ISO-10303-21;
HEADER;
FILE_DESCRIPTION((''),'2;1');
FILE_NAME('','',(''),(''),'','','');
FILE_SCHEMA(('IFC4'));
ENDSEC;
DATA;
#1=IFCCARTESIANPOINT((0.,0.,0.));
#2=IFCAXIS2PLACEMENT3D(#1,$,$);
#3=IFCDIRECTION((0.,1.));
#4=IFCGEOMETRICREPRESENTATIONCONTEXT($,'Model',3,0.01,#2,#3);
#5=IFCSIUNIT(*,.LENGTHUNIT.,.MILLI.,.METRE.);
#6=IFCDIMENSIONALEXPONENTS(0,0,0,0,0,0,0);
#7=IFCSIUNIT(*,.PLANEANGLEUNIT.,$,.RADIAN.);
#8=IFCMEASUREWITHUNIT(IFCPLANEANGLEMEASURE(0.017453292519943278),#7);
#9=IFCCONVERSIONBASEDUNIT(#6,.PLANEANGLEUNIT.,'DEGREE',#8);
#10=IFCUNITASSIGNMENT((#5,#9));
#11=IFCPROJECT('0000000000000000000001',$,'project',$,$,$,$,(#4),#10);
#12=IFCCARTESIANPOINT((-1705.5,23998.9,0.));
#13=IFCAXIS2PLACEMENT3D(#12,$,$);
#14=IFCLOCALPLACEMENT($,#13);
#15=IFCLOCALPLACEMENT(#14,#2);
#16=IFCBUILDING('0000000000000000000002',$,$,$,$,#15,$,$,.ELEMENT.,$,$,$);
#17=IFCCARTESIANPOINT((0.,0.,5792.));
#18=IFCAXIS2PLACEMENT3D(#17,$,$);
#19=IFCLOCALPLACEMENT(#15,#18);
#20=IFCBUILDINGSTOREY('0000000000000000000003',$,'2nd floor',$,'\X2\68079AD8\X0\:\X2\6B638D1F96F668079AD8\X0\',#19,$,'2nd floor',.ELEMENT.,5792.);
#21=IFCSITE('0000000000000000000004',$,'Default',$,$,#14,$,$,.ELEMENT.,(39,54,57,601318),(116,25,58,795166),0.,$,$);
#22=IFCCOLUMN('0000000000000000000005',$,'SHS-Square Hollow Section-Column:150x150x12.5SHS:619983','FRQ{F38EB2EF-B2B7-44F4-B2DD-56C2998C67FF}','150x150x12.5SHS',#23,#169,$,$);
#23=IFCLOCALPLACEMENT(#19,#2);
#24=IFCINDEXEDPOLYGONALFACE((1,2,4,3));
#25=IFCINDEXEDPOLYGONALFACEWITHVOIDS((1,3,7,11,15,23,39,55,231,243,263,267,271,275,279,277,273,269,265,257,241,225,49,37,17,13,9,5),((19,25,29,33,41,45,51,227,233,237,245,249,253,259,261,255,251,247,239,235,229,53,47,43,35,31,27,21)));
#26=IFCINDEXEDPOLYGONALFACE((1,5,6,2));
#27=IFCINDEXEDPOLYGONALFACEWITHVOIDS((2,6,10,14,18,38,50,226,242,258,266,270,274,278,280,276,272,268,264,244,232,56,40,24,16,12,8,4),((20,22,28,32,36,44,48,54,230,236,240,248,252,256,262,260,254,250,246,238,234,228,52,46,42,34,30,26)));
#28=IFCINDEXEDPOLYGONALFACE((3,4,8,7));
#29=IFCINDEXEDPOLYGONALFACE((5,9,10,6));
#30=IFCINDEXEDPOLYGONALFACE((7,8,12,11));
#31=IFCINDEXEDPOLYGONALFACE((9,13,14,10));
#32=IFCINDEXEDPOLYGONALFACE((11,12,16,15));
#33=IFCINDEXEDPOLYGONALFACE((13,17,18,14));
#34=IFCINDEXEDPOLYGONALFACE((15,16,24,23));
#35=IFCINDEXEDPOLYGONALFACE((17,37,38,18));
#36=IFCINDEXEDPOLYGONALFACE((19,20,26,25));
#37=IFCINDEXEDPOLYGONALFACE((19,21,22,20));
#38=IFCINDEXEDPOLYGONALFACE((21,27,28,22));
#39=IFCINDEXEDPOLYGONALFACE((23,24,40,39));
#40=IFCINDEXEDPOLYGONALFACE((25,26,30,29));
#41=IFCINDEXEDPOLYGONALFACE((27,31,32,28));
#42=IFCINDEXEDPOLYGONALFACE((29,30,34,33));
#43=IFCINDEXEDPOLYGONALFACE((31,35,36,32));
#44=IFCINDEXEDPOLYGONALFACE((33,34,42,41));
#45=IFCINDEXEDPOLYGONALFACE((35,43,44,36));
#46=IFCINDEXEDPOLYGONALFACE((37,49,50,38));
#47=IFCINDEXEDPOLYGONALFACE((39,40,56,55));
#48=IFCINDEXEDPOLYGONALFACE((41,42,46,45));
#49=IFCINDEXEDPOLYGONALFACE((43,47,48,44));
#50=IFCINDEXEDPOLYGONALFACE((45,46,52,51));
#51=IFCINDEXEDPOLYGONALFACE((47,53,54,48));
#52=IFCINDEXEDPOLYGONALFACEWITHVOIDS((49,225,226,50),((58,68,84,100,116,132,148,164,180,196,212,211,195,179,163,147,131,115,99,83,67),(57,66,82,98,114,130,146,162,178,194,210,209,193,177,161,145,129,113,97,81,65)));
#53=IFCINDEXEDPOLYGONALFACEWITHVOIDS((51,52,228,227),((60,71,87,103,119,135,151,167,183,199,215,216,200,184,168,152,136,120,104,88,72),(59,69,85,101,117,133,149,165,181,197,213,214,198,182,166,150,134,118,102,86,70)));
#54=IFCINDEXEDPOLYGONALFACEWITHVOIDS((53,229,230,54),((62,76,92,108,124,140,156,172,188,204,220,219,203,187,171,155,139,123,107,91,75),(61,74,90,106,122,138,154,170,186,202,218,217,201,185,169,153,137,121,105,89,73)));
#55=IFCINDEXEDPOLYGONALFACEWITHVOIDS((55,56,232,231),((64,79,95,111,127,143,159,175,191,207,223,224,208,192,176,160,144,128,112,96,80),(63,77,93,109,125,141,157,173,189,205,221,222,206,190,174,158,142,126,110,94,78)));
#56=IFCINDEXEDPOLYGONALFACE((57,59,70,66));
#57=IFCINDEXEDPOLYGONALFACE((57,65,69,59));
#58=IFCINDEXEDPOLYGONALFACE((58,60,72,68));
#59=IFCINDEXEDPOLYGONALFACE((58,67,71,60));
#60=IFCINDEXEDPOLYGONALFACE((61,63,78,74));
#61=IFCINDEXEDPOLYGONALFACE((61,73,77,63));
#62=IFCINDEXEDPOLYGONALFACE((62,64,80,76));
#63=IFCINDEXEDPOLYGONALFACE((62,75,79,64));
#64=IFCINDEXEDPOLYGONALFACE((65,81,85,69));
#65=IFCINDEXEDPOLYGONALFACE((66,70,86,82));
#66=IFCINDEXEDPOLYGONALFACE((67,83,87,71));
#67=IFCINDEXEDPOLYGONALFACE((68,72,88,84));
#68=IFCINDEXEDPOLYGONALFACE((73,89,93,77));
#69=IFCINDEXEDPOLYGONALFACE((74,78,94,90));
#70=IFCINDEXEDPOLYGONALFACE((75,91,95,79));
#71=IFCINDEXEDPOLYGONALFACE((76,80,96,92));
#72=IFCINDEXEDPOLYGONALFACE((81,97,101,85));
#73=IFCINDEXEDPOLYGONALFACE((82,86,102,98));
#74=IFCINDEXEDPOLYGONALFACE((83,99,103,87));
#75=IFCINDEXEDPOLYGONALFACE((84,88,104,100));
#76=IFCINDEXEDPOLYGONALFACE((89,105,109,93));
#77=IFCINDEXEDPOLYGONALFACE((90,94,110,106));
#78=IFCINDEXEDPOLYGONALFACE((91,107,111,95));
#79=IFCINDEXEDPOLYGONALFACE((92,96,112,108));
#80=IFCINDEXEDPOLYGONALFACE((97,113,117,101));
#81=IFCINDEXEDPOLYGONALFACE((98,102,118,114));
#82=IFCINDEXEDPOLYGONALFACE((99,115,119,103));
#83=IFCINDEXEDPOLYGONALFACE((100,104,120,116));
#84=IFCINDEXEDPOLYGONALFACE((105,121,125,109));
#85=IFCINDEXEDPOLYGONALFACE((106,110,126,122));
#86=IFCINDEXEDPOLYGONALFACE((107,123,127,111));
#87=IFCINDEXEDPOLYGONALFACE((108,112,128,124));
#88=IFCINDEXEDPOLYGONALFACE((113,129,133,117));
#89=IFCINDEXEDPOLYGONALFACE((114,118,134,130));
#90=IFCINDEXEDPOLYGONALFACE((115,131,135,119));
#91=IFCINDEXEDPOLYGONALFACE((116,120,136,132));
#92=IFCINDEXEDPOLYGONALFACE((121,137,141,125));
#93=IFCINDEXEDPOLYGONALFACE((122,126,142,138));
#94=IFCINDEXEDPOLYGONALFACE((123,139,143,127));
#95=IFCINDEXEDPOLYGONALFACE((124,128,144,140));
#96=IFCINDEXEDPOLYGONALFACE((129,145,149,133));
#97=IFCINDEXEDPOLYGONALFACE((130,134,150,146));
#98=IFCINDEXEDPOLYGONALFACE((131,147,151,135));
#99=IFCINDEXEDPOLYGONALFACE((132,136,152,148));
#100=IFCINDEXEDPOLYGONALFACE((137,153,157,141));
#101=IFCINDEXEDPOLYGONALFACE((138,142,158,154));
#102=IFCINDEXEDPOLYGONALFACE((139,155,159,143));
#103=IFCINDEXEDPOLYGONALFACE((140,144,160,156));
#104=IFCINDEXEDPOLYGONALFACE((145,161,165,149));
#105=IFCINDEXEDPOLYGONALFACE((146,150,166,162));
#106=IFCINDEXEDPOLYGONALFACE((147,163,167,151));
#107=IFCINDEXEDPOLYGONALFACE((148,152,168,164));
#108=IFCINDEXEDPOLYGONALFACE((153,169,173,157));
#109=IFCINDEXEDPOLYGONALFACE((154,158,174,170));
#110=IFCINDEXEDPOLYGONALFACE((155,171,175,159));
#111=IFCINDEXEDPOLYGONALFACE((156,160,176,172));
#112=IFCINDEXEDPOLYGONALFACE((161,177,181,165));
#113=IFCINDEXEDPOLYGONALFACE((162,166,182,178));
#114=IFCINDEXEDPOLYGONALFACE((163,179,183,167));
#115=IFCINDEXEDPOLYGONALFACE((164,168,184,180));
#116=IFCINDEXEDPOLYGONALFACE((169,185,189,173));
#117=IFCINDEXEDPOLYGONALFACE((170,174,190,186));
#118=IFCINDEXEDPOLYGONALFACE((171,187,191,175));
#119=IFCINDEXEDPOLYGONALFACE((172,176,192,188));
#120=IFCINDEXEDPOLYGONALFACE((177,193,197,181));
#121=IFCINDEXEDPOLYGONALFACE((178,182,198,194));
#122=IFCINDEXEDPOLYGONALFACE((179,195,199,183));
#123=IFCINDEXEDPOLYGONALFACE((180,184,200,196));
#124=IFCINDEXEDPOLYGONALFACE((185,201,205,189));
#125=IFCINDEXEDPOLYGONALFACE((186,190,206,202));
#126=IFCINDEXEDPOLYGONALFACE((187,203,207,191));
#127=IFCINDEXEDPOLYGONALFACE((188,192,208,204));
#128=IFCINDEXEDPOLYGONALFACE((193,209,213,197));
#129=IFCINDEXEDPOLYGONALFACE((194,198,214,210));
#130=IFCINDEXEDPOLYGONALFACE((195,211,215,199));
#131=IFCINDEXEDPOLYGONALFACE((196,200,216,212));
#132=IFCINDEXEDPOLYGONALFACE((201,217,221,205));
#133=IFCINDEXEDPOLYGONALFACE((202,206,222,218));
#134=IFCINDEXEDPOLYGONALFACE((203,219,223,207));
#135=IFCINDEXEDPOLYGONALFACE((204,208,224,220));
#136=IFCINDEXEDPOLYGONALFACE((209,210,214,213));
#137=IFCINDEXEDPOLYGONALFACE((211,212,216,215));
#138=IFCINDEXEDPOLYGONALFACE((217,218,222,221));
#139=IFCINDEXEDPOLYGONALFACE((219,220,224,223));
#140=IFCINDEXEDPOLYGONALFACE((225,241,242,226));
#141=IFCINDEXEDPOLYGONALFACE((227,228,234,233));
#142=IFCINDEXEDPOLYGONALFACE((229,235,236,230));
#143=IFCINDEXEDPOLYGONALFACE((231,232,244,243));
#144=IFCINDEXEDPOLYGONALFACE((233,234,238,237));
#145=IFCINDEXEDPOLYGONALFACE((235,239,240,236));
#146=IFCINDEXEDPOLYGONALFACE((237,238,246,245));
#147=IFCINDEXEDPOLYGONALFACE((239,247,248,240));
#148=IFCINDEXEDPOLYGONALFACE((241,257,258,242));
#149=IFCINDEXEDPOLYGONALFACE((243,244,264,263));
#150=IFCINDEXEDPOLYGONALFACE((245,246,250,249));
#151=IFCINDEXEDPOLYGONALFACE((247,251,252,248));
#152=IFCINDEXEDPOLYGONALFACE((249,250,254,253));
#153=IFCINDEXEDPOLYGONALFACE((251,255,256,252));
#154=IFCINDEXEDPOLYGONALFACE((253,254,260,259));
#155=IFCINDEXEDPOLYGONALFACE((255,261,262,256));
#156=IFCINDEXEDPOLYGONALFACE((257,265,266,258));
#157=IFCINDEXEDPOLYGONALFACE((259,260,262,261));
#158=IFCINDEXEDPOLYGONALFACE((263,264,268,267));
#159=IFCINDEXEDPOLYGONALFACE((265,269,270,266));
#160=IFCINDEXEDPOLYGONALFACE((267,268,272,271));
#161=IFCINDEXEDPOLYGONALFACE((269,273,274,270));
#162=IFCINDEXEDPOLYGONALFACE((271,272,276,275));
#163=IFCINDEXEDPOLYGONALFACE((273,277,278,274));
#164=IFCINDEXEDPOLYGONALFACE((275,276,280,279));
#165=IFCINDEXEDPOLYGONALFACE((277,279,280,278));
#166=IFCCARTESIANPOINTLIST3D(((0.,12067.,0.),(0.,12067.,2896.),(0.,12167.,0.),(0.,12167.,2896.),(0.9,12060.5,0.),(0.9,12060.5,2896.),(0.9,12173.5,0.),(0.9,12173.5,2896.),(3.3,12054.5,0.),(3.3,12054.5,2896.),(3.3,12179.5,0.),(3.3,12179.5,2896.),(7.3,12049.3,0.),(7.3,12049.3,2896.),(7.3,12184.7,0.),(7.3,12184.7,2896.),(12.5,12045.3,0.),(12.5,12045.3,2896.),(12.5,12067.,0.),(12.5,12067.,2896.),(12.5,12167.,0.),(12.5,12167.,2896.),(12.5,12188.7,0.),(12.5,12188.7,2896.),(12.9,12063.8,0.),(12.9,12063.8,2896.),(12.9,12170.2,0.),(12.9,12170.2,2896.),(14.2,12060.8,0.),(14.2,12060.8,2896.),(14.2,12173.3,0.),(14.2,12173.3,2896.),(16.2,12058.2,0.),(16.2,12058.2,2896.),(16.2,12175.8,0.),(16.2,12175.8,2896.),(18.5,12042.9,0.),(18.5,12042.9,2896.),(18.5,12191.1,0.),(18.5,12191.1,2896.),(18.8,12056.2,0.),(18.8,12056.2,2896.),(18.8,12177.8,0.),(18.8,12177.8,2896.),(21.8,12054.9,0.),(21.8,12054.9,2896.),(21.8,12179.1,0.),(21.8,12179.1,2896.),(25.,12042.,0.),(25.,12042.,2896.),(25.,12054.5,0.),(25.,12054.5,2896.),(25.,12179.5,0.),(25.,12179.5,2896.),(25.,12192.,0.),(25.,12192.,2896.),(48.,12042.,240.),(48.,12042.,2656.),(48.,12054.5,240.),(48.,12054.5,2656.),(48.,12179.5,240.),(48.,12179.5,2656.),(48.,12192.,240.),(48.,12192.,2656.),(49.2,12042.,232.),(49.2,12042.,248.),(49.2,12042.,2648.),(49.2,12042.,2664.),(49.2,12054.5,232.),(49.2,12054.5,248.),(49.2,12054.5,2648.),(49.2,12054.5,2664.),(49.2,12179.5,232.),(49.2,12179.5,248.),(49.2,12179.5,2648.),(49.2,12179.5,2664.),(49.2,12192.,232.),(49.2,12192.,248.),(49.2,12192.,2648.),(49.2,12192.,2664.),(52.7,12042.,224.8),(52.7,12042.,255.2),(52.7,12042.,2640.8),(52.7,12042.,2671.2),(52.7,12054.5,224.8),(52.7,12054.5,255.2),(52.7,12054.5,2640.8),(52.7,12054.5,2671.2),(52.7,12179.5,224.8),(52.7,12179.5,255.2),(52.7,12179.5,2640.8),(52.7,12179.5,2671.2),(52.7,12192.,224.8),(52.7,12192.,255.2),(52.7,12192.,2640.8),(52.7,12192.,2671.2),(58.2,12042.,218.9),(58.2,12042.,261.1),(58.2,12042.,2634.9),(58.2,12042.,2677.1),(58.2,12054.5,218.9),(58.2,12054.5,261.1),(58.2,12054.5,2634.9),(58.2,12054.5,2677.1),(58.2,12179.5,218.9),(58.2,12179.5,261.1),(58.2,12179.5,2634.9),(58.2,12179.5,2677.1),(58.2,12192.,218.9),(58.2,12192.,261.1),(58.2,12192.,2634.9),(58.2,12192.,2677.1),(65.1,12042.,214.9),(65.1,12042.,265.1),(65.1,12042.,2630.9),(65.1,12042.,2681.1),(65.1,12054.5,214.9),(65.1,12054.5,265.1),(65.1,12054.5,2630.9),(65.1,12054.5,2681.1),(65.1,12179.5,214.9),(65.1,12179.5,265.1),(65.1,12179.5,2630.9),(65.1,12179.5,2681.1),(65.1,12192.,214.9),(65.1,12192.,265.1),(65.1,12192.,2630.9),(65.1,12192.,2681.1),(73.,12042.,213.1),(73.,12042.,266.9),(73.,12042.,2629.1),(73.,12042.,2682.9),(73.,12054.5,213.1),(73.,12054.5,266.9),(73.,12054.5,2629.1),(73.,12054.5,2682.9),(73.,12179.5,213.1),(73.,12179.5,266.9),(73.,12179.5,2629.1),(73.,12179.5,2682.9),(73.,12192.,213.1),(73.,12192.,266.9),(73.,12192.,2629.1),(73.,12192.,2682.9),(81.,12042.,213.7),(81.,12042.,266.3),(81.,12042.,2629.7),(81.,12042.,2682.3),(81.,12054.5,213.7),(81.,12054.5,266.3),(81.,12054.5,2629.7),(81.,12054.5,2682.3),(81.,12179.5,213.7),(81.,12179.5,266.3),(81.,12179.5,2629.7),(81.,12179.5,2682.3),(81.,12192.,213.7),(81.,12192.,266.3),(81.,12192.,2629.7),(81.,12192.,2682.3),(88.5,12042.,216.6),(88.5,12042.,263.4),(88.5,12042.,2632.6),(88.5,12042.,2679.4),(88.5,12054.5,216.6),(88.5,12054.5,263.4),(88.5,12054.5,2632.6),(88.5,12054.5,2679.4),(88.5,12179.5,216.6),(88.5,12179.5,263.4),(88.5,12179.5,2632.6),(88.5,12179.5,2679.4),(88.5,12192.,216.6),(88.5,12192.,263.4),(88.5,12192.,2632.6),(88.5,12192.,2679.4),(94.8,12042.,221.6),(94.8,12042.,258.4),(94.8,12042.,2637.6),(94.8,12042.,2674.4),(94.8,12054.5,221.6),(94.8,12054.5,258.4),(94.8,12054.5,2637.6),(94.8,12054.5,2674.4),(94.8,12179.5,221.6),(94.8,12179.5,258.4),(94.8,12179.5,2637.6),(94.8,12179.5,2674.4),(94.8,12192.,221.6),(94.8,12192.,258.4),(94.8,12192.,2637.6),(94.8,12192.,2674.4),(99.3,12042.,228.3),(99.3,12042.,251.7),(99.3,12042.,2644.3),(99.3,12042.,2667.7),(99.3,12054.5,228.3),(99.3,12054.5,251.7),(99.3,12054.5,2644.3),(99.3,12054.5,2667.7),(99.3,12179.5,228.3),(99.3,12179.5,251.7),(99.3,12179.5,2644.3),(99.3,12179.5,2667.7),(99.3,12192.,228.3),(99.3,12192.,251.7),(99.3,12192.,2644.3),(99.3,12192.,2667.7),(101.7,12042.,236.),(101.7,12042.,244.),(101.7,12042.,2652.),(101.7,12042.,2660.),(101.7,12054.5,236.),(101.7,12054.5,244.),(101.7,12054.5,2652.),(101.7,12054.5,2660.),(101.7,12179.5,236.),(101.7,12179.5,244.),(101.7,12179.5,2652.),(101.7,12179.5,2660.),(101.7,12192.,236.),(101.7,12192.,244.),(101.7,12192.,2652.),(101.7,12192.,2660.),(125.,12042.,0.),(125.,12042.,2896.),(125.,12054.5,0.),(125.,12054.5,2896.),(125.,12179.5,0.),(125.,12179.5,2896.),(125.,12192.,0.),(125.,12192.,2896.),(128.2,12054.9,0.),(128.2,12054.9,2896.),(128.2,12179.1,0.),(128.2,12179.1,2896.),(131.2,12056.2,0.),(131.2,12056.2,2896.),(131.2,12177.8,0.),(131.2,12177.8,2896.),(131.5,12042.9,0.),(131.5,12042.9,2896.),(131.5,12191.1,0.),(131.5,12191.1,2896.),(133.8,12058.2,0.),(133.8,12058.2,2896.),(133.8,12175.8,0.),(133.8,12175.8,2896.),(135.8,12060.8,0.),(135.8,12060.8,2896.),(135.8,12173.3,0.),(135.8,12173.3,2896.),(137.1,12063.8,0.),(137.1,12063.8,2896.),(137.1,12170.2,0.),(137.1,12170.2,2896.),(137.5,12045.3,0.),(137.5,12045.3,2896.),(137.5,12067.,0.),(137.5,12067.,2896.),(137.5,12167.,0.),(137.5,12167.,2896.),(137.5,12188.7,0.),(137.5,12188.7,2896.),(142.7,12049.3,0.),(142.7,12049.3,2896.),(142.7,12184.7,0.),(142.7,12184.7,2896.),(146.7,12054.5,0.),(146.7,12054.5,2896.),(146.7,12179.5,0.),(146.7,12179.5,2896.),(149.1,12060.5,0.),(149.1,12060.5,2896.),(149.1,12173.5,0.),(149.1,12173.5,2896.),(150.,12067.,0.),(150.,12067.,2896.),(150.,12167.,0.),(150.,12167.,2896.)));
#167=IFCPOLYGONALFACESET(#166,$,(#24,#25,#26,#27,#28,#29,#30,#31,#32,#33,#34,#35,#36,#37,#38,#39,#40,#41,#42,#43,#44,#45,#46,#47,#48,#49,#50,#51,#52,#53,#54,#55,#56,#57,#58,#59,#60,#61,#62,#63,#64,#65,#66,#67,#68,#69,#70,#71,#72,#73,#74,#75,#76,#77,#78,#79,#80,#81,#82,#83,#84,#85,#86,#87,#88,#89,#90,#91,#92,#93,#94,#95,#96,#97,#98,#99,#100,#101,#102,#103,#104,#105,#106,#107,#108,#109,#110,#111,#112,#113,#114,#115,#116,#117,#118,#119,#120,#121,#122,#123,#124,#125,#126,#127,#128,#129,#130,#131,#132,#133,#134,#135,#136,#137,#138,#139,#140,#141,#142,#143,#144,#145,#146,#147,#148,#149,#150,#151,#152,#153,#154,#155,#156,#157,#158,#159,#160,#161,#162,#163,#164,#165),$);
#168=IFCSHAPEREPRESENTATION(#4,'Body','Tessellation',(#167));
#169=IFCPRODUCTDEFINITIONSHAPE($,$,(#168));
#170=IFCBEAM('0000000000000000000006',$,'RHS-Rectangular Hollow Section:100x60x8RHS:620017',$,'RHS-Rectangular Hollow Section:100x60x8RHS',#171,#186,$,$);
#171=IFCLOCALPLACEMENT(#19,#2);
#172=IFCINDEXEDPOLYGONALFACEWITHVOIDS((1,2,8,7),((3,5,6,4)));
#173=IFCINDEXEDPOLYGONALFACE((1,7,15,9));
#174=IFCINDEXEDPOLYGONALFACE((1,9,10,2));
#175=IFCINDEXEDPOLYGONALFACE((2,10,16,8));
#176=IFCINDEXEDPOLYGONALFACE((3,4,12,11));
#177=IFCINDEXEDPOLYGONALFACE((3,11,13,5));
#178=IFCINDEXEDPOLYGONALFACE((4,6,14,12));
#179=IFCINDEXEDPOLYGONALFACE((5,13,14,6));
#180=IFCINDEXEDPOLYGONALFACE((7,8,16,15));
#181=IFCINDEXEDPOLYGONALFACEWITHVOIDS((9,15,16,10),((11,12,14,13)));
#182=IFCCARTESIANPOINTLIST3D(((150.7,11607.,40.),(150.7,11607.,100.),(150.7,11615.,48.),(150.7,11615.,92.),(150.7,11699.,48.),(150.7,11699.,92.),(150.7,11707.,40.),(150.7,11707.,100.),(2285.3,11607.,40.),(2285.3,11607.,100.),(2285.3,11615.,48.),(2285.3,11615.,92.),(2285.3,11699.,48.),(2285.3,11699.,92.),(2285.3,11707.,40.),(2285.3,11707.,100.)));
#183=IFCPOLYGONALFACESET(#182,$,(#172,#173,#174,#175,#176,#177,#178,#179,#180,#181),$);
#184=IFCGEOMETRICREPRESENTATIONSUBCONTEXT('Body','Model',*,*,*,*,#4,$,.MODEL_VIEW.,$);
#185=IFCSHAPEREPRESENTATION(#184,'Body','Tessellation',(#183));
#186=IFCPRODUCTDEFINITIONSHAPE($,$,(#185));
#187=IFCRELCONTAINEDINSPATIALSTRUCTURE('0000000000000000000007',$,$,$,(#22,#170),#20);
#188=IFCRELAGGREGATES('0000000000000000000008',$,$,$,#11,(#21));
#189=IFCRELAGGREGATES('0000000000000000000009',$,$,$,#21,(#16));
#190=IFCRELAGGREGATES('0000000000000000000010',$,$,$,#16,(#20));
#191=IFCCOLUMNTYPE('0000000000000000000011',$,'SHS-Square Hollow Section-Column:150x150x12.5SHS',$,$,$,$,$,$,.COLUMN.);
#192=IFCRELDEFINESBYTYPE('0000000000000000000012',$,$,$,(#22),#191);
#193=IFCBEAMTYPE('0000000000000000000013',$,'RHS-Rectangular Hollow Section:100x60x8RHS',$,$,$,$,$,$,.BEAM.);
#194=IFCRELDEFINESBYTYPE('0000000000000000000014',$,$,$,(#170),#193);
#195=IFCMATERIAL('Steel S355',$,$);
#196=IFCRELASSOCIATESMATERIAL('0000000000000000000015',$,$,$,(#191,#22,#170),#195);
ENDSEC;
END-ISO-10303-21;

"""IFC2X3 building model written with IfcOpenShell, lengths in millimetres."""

from ifc_helpers import new_model, entity, si_unit, converted_unit, direction, frame, frame_2d, origin, origin_2d, place, context, subcontext, project, spatial, circle_curve, rectangle, hollow_rectangle, outline, extrude, boolean, material, type_object, element, save


model = new_model("IFC2X3")

# Units and contexts
model_context = context("Model", 3, precision=0.01, world=origin(), true_north=direction((0.0, 1.0)))
body_context = subcontext(model_context, "Body", "Model", "MODEL_VIEW")
ifc_project = project(units=[si_unit("LENGTHUNIT", "METRE", prefix="MILLI"), converted_unit("PLANEANGLEUNIT", "DEGREE", entity("IfcPlaneAngleMeasure", 0.017453292519943278), si_unit("PLANEANGLEUNIT", "RADIAN"), dimensions=[0, 0, 0, 0, 0, 0, 0])], contexts=[model_context])

# Site, building, storey
site_placement = place(None, frame((-1705.5, 23998.9, 0.0)))
site = spatial("IfcSite", under=ifc_project, at=site_placement, Name="Default", CompositionType="ELEMENT", RefLatitude=(39, 54, 57, 601318), RefLongitude=(116, 25, 58, 795166), RefElevation=0.0)
building_placement = place(site_placement, origin())
building = spatial("IfcBuilding", under=site, at=building_placement, CompositionType="ELEMENT")
storey_placement = place(building_placement, frame((0.0, 0.0, 5792.0)))
storey = spatial("IfcBuildingStorey", under=building, at=storey_placement, Name="2nd floor", ObjectType="标高:正负零标高", LongName="2nd floor", CompositionType="ELEMENT", Elevation=5792.0)

# Shared definitions
ifc_material_1 = material(Name="Steel S355")

# Column, openings
column_type_1 = type_object("IfcColumnType", Name="SHS-Square Hollow Section-Column:150x150x12.5SHS", PredefinedType="COLUMN", material=ifc_material_1)
column_1_placement = place(storey_placement, frame((75.0, 12117.0, 2896.0), z_axis=(0.0, 0.0, 1.0), x_axis=(0.0, -1.0, 0.0)))
column_1 = element("IfcColumn", 1, at=column_1_placement, inside=storey, type_object=column_type_1, material=ifc_material_1, Name="SHS-Square Hollow Section-Column:150x150x12.5SHS:619983", Description="FRQ{F38EB2EF-B2B7-44F4-B2DD-56C2998C67FF}", ObjectType="150x150x12.5SHS", context=model_context, shape_type="SweptSolid", body=[
    extrude(hollow_rectangle(XDim=150.0, YDim=150.0, WallThickness=12.5, InnerFilletRadius=12.5, OuterFilletRadius=25.0, at=origin_2d()), origin(), (0.0, 0.0, -1.0), 2896.0),
])
opening_1_placement = place(column_1_placement, frame((175.1, 0.0, -2896.0), z_axis=(-1.0, 0.0, 0.0), x_axis=(0.0, -1.0, 0.0)))
element("IfcOpeningElement", 2, at=opening_1_placement, cuts=column_1, ObjectType="Opening", context=model_context, shape_type="SweptSolid", body=[
    extrude(outline(circle_curve(frame_2d((0.0, 240.0), x_axis=(1.0, 0.0)), 27.0)), origin(), (0.0, 0.0, 1.0), 350.2),
])
opening_2_placement = place(column_1_placement, frame((175.1, 0.0, 0.0), z_axis=(-1.0, 0.0, 0.0), x_axis=(0.0, -1.0, 0.0)))
element("IfcOpeningElement", 3, at=opening_2_placement, cuts=column_1, ObjectType="Opening", context=model_context, shape_type="SweptSolid", body=[
    extrude(outline(circle_curve(frame_2d((0.0, -240.0), x_axis=(1.0, 0.0)), 27.0)), origin(), (0.0, 0.0, 1.0), 350.2),
])

# Beam
beam_type_1 = type_object("IfcBeamType", Name="RHS-Rectangular Hollow Section:100x60x8RHS", PredefinedType="BEAM")
beam_1_placement = place(storey_placement, frame((150.7, 11707.0, 70.0)))
element("IfcBeam", 4, at=beam_1_placement, inside=storey, type_object=beam_type_1, material=ifc_material_1, Name="RHS-Rectangular Hollow Section:100x60x8RHS:620017", ObjectType="RHS-Rectangular Hollow Section:100x60x8RHS", context=body_context, shape_type="SweptSolid", body=[
    boolean("DIFFERENCE", extrude(rectangle(XDim=60.0, YDim=100.0, at=frame_2d((0.0, 0.0), x_axis=(1.0, 0.0))), frame((0.0, -50.0, 0.0), z_axis=(1.0, 0.0, 0.0), x_axis=(0.0, 0.0, -1.0)), (0.0, 0.0, 1.0), 2134.6), extrude(rectangle(XDim=44.0, YDim=84.0, at=frame_2d((0.0, 0.0), x_axis=(0.0, 1.0))), frame((2134.6, -50.0, 0.0), z_axis=(-1.0, 0.0, 0.0), x_axis=(0.0, 1.0, 0.0)), (0.0, 0.0, 1.0), 2134.6)),
])

save(model, "model.ifc")
